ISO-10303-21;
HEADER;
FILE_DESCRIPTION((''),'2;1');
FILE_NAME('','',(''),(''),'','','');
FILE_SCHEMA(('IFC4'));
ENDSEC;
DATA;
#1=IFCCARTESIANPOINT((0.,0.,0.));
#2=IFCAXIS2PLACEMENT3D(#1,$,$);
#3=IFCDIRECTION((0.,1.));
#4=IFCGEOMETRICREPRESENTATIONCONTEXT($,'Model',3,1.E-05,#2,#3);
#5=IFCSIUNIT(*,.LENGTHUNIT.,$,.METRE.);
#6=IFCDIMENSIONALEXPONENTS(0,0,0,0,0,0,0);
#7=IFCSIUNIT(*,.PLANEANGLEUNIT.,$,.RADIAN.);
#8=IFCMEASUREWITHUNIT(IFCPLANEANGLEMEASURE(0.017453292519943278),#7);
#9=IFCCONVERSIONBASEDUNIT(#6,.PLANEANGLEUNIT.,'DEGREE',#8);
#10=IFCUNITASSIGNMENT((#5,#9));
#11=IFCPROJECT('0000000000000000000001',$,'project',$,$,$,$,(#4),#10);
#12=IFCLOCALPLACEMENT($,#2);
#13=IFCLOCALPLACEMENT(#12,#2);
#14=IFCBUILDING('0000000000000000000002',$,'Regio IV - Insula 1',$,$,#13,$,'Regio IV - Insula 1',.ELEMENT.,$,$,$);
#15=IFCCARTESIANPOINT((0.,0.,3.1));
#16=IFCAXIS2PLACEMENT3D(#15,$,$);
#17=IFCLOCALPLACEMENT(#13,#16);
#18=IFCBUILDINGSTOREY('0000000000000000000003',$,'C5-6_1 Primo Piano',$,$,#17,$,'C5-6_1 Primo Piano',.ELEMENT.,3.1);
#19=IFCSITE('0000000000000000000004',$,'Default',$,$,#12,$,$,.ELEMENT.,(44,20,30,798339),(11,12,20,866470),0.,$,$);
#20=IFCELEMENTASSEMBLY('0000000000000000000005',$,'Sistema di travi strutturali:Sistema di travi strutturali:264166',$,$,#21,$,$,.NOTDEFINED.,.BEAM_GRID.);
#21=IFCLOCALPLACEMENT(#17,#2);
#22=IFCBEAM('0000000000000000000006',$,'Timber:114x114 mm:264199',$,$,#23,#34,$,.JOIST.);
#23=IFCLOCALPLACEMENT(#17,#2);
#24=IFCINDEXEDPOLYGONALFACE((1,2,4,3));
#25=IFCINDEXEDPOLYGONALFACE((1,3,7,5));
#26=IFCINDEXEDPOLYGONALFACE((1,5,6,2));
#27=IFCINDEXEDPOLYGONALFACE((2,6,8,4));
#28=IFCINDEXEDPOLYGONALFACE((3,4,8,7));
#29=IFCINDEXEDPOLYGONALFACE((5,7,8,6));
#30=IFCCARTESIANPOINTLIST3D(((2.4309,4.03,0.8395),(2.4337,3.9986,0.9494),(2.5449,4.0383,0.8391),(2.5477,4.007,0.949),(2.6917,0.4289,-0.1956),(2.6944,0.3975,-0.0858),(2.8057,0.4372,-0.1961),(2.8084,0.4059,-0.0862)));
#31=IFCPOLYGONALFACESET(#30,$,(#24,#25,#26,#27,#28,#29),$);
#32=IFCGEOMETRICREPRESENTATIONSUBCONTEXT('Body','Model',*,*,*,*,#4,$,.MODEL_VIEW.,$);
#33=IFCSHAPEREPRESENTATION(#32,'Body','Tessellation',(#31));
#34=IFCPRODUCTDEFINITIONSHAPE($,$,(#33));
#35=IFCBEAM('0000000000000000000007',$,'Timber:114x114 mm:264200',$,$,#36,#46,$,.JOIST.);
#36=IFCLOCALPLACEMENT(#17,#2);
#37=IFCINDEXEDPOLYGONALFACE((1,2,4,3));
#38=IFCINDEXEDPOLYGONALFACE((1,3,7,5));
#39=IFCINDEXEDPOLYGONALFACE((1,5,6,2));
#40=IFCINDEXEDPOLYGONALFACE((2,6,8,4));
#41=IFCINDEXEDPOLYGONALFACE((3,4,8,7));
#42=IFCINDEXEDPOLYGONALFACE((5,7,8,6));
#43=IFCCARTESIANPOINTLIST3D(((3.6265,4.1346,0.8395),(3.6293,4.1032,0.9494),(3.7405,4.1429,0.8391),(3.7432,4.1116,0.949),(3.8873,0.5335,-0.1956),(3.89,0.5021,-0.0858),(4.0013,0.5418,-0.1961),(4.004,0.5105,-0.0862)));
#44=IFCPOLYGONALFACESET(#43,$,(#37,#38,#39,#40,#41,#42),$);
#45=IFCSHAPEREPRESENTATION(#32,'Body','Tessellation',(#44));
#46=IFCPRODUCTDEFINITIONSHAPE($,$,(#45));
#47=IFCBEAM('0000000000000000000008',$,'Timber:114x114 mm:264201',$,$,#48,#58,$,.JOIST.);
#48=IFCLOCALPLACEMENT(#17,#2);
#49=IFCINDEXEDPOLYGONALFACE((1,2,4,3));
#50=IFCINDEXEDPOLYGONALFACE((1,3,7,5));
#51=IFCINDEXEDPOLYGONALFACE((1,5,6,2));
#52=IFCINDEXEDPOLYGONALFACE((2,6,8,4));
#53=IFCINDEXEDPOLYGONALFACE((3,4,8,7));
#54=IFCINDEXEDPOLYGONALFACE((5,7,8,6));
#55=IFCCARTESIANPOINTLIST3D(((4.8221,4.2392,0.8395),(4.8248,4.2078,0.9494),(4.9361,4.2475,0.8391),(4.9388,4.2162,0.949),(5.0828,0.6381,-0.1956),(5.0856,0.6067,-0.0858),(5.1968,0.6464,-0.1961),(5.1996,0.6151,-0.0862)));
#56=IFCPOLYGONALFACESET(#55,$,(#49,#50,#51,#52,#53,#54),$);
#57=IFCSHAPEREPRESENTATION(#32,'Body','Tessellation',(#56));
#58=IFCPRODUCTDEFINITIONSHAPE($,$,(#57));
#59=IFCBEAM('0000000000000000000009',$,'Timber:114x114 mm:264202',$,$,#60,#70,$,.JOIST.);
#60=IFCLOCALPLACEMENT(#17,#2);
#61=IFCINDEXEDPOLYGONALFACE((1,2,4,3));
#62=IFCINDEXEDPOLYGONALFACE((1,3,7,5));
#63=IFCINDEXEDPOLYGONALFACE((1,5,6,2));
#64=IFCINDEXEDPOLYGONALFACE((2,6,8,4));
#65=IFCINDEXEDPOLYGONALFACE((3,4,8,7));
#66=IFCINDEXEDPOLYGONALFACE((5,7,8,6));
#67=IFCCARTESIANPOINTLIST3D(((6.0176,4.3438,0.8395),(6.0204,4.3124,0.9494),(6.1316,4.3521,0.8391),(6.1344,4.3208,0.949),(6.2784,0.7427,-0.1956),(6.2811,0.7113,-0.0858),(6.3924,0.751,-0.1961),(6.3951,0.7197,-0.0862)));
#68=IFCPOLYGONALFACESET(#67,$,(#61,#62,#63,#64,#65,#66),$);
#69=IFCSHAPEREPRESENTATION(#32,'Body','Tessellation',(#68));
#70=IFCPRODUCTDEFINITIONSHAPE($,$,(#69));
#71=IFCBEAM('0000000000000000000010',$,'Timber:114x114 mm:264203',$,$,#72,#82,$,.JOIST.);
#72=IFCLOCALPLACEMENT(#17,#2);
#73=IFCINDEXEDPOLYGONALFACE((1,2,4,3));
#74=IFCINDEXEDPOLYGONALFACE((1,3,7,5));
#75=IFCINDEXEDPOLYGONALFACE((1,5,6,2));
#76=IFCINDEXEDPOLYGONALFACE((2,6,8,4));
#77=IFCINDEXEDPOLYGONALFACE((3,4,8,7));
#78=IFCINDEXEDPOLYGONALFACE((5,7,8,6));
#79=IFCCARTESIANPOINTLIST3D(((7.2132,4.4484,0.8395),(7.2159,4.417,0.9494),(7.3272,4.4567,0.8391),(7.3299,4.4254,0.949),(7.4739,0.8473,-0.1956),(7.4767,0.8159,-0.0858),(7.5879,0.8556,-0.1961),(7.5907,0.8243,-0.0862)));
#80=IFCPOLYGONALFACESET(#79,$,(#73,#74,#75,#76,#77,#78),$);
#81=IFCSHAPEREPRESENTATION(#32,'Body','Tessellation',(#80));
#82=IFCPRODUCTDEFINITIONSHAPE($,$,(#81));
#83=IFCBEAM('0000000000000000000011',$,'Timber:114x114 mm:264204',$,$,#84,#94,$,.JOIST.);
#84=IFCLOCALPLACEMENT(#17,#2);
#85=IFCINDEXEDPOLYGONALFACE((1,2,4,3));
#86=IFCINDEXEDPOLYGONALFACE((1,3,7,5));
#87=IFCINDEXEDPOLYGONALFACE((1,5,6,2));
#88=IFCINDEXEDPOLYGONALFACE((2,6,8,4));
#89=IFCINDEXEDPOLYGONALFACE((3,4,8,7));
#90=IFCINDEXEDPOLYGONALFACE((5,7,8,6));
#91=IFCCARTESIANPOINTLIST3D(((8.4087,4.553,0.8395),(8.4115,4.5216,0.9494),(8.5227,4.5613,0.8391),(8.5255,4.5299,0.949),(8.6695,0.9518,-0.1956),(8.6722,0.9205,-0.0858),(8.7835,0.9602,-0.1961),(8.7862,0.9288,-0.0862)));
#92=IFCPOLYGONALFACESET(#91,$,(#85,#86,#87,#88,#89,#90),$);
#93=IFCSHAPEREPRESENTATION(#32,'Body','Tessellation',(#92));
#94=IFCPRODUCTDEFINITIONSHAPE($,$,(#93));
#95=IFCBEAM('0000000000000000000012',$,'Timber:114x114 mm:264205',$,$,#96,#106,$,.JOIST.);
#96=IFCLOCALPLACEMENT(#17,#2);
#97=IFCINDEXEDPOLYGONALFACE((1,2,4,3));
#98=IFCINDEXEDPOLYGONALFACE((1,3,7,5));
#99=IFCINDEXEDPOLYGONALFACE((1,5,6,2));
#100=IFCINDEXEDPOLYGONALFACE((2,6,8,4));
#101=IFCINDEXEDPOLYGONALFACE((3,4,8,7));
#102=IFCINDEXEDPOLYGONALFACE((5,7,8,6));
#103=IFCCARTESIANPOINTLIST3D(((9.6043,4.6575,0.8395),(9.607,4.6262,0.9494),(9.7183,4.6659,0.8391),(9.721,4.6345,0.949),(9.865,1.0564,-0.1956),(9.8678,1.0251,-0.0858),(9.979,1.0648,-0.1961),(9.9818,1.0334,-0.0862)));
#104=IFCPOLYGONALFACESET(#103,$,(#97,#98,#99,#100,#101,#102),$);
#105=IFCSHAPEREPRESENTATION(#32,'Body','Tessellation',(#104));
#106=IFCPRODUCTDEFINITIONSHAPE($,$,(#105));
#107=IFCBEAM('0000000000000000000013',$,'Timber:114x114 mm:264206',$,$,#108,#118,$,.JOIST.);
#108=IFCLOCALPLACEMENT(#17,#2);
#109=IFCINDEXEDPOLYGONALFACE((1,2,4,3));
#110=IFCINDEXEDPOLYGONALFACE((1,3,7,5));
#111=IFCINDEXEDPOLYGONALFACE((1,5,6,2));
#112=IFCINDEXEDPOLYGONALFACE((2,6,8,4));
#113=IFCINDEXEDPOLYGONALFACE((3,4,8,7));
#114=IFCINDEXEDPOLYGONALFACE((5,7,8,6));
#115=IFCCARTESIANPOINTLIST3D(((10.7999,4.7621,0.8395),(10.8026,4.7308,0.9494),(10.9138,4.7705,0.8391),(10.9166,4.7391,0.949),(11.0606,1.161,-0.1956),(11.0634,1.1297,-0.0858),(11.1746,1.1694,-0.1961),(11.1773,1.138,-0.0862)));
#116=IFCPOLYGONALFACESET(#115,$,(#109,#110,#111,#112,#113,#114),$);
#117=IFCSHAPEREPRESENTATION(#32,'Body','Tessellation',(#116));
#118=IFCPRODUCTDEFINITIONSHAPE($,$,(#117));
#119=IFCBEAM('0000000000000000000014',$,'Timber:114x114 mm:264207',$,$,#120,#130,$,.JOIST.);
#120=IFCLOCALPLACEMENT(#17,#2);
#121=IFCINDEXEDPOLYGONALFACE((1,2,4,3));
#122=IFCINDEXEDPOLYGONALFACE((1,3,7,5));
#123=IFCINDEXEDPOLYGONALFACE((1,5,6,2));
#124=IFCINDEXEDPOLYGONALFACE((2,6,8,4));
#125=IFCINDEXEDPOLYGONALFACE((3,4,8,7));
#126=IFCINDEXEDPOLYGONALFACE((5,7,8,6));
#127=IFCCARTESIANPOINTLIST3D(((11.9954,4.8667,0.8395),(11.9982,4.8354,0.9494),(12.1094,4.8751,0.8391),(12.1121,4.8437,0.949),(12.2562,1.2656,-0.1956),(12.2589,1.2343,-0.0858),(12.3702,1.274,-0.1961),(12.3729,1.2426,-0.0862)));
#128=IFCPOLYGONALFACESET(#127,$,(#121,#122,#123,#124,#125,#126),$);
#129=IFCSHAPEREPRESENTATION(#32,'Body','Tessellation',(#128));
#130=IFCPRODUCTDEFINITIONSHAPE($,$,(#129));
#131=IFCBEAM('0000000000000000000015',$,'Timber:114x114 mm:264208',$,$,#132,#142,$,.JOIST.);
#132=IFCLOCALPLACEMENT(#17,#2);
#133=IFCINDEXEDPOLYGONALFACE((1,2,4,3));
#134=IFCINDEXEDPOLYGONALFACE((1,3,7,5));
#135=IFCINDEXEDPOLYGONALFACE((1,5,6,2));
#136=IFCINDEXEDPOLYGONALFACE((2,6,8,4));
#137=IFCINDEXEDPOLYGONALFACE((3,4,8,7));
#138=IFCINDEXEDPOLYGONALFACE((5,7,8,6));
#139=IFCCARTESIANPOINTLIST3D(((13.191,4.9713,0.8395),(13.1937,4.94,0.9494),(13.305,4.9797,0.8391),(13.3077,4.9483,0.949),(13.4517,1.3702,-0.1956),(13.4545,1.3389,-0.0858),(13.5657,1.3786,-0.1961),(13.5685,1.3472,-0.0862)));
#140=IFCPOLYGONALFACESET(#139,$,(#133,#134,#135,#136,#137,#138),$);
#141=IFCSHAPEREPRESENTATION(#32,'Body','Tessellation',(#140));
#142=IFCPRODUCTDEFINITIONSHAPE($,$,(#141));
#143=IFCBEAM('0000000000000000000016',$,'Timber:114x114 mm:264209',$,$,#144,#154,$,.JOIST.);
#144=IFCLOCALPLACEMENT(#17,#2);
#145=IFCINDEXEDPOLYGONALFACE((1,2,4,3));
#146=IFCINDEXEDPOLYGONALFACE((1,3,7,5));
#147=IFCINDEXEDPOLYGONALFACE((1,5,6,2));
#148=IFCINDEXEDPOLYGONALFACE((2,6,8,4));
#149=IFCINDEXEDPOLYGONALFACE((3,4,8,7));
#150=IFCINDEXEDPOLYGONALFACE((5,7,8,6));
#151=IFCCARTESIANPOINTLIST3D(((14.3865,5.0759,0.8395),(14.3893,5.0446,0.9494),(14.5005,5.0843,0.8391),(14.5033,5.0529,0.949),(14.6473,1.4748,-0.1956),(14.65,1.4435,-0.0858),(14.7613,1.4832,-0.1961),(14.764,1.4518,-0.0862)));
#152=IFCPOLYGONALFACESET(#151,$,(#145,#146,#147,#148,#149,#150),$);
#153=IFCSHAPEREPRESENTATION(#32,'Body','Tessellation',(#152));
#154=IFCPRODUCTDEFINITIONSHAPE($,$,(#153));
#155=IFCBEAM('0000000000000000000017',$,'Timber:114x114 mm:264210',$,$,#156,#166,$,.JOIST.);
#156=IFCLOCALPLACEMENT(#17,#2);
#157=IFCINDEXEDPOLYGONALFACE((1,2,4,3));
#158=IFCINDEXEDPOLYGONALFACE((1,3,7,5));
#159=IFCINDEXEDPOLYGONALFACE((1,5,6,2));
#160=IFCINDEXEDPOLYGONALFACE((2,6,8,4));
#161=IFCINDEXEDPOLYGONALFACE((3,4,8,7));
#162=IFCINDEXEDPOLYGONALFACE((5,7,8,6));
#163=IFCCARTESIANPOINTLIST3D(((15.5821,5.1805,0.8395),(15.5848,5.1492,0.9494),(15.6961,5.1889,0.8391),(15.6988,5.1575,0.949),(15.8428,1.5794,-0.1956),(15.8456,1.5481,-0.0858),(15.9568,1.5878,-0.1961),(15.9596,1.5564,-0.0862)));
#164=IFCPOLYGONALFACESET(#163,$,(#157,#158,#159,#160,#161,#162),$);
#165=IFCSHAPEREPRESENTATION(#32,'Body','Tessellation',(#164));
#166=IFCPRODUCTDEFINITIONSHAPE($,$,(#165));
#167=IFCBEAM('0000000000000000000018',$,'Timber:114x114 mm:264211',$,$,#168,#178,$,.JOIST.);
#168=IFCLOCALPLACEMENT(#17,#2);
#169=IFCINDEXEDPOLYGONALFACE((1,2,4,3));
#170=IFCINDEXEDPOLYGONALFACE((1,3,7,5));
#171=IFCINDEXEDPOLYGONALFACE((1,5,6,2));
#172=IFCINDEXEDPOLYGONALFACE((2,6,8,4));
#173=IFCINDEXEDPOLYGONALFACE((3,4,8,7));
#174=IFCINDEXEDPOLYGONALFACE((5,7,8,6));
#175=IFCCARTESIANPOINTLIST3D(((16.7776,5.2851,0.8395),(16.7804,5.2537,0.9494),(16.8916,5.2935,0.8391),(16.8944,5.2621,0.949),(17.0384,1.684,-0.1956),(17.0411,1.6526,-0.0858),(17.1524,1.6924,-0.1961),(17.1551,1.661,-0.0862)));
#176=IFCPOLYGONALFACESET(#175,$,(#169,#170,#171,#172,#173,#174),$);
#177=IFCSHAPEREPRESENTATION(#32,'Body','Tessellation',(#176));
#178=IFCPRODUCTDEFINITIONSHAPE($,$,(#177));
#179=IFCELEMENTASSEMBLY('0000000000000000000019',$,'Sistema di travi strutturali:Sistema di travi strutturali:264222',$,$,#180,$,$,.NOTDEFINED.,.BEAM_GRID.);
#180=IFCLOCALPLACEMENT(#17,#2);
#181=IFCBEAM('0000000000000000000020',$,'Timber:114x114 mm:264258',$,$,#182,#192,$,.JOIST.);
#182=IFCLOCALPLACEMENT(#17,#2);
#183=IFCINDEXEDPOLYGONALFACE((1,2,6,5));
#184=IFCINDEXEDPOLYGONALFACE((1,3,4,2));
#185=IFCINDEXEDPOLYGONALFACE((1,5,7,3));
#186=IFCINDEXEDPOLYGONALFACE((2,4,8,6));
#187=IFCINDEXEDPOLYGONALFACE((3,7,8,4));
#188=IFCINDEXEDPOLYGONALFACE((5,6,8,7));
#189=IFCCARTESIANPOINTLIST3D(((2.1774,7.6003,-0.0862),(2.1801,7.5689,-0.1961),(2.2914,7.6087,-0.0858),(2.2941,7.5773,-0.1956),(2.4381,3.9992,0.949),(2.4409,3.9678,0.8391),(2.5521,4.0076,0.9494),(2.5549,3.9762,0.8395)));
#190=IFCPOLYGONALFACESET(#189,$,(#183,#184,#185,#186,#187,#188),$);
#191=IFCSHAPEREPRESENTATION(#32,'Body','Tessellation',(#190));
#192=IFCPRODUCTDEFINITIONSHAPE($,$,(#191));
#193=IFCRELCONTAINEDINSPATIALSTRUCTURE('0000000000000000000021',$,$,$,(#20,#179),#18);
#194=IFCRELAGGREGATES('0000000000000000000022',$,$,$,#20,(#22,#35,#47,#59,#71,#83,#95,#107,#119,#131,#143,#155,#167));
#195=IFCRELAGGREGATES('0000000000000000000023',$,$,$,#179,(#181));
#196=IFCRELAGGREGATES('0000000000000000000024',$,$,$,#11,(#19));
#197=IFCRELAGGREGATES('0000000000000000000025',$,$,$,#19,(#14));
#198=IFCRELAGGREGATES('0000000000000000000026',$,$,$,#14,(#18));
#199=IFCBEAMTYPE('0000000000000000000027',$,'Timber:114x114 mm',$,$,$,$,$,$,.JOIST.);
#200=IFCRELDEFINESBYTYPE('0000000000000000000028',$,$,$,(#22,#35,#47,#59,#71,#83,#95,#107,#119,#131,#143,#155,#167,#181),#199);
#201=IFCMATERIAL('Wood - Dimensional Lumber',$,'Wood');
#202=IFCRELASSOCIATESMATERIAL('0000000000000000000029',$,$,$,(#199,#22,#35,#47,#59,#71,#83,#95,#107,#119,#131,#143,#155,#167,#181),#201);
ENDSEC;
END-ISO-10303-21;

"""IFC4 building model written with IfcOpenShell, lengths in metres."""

from ifc_helpers import new_model, entity, si_unit, converted_unit, direction, frame, origin, origin_2d_with_axis, place, context, subcontext, project, spatial, rectangle, extrude, source, transform, mapped, material, material_profile, profile_set, profile_usage, type_object, type_shapes, element, aggregate, save


model = new_model("IFC4")

# Units and contexts
model_context = context("Model", 3, precision=1e-05, world=origin(), true_north=direction((0.0, 1.0)))
body_context = subcontext(model_context, "Body", "Model", "MODEL_VIEW")
ifc_project = project(units=[si_unit("LENGTHUNIT", "METRE"), converted_unit("PLANEANGLEUNIT", "DEGREE", entity("IfcPlaneAngleMeasure", 0.017453292519943278), si_unit("PLANEANGLEUNIT", "RADIAN"), dimensions=[0, 0, 0, 0, 0, 0, 0])], contexts=[model_context])

# Site, building, storey
site_placement = place(None, origin())
site = spatial("IfcSite", under=ifc_project, at=site_placement, Name="Default", CompositionType="ELEMENT", RefLatitude=(44, 20, 30, 798339), RefLongitude=(11, 12, 20, 866470), RefElevation=0.0)
building_placement = place(site_placement, origin())
building = spatial("IfcBuilding", under=site, at=building_placement, Name="Regio IV - Insula 1", LongName="Regio IV - Insula 1", CompositionType="ELEMENT")
storey_placement = place(building_placement, frame((0.0, 0.0, 3.1)))
storey = spatial("IfcBuildingStorey", under=building, at=storey_placement, Name="C5-6_1 Primo Piano", LongName="C5-6_1 Primo Piano", CompositionType="ELEMENT", Elevation=3.1)

# Element assemblies, beams
assembly_1_placement = place(storey_placement, origin())
assembly_1 = element("IfcElementAssembly", 1, at=assembly_1_placement, inside=storey, Name="Sistema di travi strutturali:Sistema di travi strutturali:264166", AssemblyPlace="NOTDEFINED", PredefinedType="BEAM_GRID")
ifc_material_1 = material(Name="Wood - Dimensional Lumber", Category="Wood")
ifc_material_profile_1 = material_profile(ifc_material_1, rectangle(XDim=5.294, YDim=0.1143, at=origin_2d_with_axis()), Name="114x114 mm")
ifc_profile_set_1 = profile_set([ifc_material_profile_1], Name="114x114 mm")
ifc_profile_usage_1 = profile_usage(ifc_profile_set_1, cardinal=8)
beam_type_1 = type_object("IfcBeamType", Name="Timber:114x114 mm", PredefinedType="JOIST", material=ifc_profile_set_1)
shared_shape_1 = source(origin(), body_context, "Body", "SweptSolid", [
    extrude(rectangle(XDim=3.756, YDim=0.1143, at=origin_2d_with_axis()), frame((0.0, 0.0, -0.0572), z_axis=(0.0, 0.0, 1.0), x_axis=(-1.0, 0.0, 0.0)), (0.0, 0.0, 1.0), 0.1143),
])
type_shapes(beam_type_1, [shared_shape_1])
beam_1_placement = place(assembly_1_placement, frame((2.6197, 2.2179, 0.3767), z_axis=(0.024023, -0.274588, 0.961262), x_axis=(0.069423, -0.95876, -0.275609)))
beam_1 = element("IfcBeam", 2, at=beam_1_placement, type_object=beam_type_1, material=ifc_profile_usage_1, Name="Timber:114x114 mm:264199", PredefinedType="JOIST", context=body_context, shape_type="MappedRepresentation", body=[
    mapped(shared_shape_1, transform((0.0, 0.0, 0.0), scale=1.0)),
])
beam_2_placement = place(assembly_1_placement, frame((3.8153, 2.3225, 0.3767), z_axis=(0.024023, -0.274588, 0.961262), x_axis=(0.069423, -0.95876, -0.275609)))
beam_2 = element("IfcBeam", 3, at=beam_2_placement, type_object=beam_type_1, material=ifc_profile_usage_1, Name="Timber:114x114 mm:264200", PredefinedType="JOIST", context=body_context, shape_type="MappedRepresentation", body=[
    mapped(shared_shape_1, transform((0.0, 0.0, 0.0), scale=1.0)),
])
beam_3_placement = place(assembly_1_placement, frame((5.0108, 2.4271, 0.3767), z_axis=(0.024023, -0.274588, 0.961262), x_axis=(0.069423, -0.95876, -0.275609)))
beam_3 = element("IfcBeam", 4, at=beam_3_placement, type_object=beam_type_1, material=ifc_profile_usage_1, Name="Timber:114x114 mm:264201", PredefinedType="JOIST", context=body_context, shape_type="MappedRepresentation", body=[
    mapped(shared_shape_1, transform((0.0, 0.0, 0.0), scale=1.0)),
])
beam_4_placement = place(assembly_1_placement, frame((6.2064, 2.5317, 0.3767), z_axis=(0.024023, -0.274588, 0.961262), x_axis=(0.069423, -0.95876, -0.275609)))
beam_4 = element("IfcBeam", 5, at=beam_4_placement, type_object=beam_type_1, material=ifc_profile_usage_1, Name="Timber:114x114 mm:264202", PredefinedType="JOIST", context=body_context, shape_type="MappedRepresentation", body=[
    mapped(shared_shape_1, transform((0.0, 0.0, 0.0), scale=1.0)),
])
beam_5_placement = place(assembly_1_placement, frame((7.4019, 2.6363, 0.3767), z_axis=(0.024023, -0.274588, 0.961262), x_axis=(0.069423, -0.95876, -0.275609)))
beam_5 = element("IfcBeam", 6, at=beam_5_placement, type_object=beam_type_1, material=ifc_profile_usage_1, Name="Timber:114x114 mm:264203", PredefinedType="JOIST", context=body_context, shape_type="MappedRepresentation", body=[
    mapped(shared_shape_1, transform((0.0, 0.0, 0.0), scale=1.0)),
])
beam_6_placement = place(assembly_1_placement, frame((8.5975, 2.7409, 0.3767), z_axis=(0.024023, -0.274588, 0.961262), x_axis=(0.069423, -0.95876, -0.275609)))
beam_6 = element("IfcBeam", 7, at=beam_6_placement, type_object=beam_type_1, material=ifc_profile_usage_1, Name="Timber:114x114 mm:264204", PredefinedType="JOIST", context=body_context, shape_type="MappedRepresentation", body=[
    mapped(shared_shape_1, transform((0.0, 0.0, 0.0), scale=1.0)),
])
beam_7_placement = place(assembly_1_placement, frame((9.793, 2.8455, 0.3767), z_axis=(0.024023, -0.274588, 0.961262), x_axis=(0.069423, -0.95876, -0.275609)))
beam_7 = element("IfcBeam", 8, at=beam_7_placement, type_object=beam_type_1, material=ifc_profile_usage_1, Name="Timber:114x114 mm:264205", PredefinedType="JOIST", context=body_context, shape_type="MappedRepresentation", body=[
    mapped(shared_shape_1, transform((0.0, 0.0, 0.0), scale=1.0)),
])
beam_8_placement = place(assembly_1_placement, frame((10.9886, 2.9501, 0.3767), z_axis=(0.024023, -0.274588, 0.961262), x_axis=(0.069423, -0.95876, -0.275609)))
beam_8 = element("IfcBeam", 9, at=beam_8_placement, type_object=beam_type_1, material=ifc_profile_usage_1, Name="Timber:114x114 mm:264206", PredefinedType="JOIST", context=body_context, shape_type="MappedRepresentation", body=[
    mapped(shared_shape_1, transform((0.0, 0.0, 0.0), scale=1.0)),
])
beam_9_placement = place(assembly_1_placement, frame((12.1842, 3.0547, 0.3767), z_axis=(0.024023, -0.274588, 0.961262), x_axis=(0.069423, -0.95876, -0.275609)))
beam_9 = element("IfcBeam", 10, at=beam_9_placement, type_object=beam_type_1, material=ifc_profile_usage_1, Name="Timber:114x114 mm:264207", PredefinedType="JOIST", context=body_context, shape_type="MappedRepresentation", body=[
    mapped(shared_shape_1, transform((0.0, 0.0, 0.0), scale=1.0)),
])
beam_10_placement = place(assembly_1_placement, frame((13.3797, 3.1593, 0.3767), z_axis=(0.024023, -0.274588, 0.961262), x_axis=(0.069423, -0.95876, -0.275609)))
beam_10 = element("IfcBeam", 11, at=beam_10_placement, type_object=beam_type_1, material=ifc_profile_usage_1, Name="Timber:114x114 mm:264208", PredefinedType="JOIST", context=body_context, shape_type="MappedRepresentation", body=[
    mapped(shared_shape_1, transform((0.0, 0.0, 0.0), scale=1.0)),
])
beam_11_placement = place(assembly_1_placement, frame((14.5753, 3.2639, 0.3767), z_axis=(0.024023, -0.274588, 0.961262), x_axis=(0.069423, -0.95876, -0.275609)))
beam_11 = element("IfcBeam", 12, at=beam_11_placement, type_object=beam_type_1, material=ifc_profile_usage_1, Name="Timber:114x114 mm:264209", PredefinedType="JOIST", context=body_context, shape_type="MappedRepresentation", body=[
    mapped(shared_shape_1, transform((0.0, 0.0, 0.0), scale=1.0)),
])
beam_12_placement = place(assembly_1_placement, frame((15.7708, 3.3685, 0.3767), z_axis=(0.024023, -0.274588, 0.961262), x_axis=(0.069423, -0.95876, -0.275609)))
beam_12 = element("IfcBeam", 13, at=beam_12_placement, type_object=beam_type_1, material=ifc_profile_usage_1, Name="Timber:114x114 mm:264210", PredefinedType="JOIST", context=body_context, shape_type="MappedRepresentation", body=[
    mapped(shared_shape_1, transform((0.0, 0.0, 0.0), scale=1.0)),
])
beam_13_placement = place(assembly_1_placement, frame((16.9664, 3.4731, 0.3767), z_axis=(0.024023, -0.274588, 0.961262), x_axis=(0.069423, -0.95876, -0.275609)))
beam_13 = element("IfcBeam", 14, at=beam_13_placement, type_object=beam_type_1, material=ifc_profile_usage_1, Name="Timber:114x114 mm:264211", PredefinedType="JOIST", context=body_context, shape_type="MappedRepresentation", body=[
    mapped(shared_shape_1, transform((0.0, 0.0, 0.0), scale=1.0)),
])
aggregate(assembly_1, [beam_1, beam_2, beam_3, beam_4, beam_5, beam_6, beam_7, beam_8, beam_9, beam_10, beam_11, beam_12, beam_13])
assembly_2_placement = place(storey_placement, origin())
assembly_2 = element("IfcElementAssembly", 15, at=assembly_2_placement, inside=storey, Name="Sistema di travi strutturali:Sistema di travi strutturali:264222", AssemblyPlace="NOTDEFINED", PredefinedType="BEAM_GRID")
beam_14_placement = place(assembly_2_placement, frame((2.3661, 5.7882, 0.3767), z_axis=(-0.024023, 0.274588, 0.961262), x_axis=(0.069423, -0.95876, 0.275609)))
beam_14 = element("IfcBeam", 16, at=beam_14_placement, type_object=beam_type_1, material=ifc_profile_usage_1, Name="Timber:114x114 mm:264258", PredefinedType="JOIST", context=body_context, shape_type="MappedRepresentation", body=[
    mapped(shared_shape_1, transform((0.0, 0.0, 0.0), scale=1.0)),
])
aggregate(assembly_2, [beam_14])

save(model, "model.ifc")
